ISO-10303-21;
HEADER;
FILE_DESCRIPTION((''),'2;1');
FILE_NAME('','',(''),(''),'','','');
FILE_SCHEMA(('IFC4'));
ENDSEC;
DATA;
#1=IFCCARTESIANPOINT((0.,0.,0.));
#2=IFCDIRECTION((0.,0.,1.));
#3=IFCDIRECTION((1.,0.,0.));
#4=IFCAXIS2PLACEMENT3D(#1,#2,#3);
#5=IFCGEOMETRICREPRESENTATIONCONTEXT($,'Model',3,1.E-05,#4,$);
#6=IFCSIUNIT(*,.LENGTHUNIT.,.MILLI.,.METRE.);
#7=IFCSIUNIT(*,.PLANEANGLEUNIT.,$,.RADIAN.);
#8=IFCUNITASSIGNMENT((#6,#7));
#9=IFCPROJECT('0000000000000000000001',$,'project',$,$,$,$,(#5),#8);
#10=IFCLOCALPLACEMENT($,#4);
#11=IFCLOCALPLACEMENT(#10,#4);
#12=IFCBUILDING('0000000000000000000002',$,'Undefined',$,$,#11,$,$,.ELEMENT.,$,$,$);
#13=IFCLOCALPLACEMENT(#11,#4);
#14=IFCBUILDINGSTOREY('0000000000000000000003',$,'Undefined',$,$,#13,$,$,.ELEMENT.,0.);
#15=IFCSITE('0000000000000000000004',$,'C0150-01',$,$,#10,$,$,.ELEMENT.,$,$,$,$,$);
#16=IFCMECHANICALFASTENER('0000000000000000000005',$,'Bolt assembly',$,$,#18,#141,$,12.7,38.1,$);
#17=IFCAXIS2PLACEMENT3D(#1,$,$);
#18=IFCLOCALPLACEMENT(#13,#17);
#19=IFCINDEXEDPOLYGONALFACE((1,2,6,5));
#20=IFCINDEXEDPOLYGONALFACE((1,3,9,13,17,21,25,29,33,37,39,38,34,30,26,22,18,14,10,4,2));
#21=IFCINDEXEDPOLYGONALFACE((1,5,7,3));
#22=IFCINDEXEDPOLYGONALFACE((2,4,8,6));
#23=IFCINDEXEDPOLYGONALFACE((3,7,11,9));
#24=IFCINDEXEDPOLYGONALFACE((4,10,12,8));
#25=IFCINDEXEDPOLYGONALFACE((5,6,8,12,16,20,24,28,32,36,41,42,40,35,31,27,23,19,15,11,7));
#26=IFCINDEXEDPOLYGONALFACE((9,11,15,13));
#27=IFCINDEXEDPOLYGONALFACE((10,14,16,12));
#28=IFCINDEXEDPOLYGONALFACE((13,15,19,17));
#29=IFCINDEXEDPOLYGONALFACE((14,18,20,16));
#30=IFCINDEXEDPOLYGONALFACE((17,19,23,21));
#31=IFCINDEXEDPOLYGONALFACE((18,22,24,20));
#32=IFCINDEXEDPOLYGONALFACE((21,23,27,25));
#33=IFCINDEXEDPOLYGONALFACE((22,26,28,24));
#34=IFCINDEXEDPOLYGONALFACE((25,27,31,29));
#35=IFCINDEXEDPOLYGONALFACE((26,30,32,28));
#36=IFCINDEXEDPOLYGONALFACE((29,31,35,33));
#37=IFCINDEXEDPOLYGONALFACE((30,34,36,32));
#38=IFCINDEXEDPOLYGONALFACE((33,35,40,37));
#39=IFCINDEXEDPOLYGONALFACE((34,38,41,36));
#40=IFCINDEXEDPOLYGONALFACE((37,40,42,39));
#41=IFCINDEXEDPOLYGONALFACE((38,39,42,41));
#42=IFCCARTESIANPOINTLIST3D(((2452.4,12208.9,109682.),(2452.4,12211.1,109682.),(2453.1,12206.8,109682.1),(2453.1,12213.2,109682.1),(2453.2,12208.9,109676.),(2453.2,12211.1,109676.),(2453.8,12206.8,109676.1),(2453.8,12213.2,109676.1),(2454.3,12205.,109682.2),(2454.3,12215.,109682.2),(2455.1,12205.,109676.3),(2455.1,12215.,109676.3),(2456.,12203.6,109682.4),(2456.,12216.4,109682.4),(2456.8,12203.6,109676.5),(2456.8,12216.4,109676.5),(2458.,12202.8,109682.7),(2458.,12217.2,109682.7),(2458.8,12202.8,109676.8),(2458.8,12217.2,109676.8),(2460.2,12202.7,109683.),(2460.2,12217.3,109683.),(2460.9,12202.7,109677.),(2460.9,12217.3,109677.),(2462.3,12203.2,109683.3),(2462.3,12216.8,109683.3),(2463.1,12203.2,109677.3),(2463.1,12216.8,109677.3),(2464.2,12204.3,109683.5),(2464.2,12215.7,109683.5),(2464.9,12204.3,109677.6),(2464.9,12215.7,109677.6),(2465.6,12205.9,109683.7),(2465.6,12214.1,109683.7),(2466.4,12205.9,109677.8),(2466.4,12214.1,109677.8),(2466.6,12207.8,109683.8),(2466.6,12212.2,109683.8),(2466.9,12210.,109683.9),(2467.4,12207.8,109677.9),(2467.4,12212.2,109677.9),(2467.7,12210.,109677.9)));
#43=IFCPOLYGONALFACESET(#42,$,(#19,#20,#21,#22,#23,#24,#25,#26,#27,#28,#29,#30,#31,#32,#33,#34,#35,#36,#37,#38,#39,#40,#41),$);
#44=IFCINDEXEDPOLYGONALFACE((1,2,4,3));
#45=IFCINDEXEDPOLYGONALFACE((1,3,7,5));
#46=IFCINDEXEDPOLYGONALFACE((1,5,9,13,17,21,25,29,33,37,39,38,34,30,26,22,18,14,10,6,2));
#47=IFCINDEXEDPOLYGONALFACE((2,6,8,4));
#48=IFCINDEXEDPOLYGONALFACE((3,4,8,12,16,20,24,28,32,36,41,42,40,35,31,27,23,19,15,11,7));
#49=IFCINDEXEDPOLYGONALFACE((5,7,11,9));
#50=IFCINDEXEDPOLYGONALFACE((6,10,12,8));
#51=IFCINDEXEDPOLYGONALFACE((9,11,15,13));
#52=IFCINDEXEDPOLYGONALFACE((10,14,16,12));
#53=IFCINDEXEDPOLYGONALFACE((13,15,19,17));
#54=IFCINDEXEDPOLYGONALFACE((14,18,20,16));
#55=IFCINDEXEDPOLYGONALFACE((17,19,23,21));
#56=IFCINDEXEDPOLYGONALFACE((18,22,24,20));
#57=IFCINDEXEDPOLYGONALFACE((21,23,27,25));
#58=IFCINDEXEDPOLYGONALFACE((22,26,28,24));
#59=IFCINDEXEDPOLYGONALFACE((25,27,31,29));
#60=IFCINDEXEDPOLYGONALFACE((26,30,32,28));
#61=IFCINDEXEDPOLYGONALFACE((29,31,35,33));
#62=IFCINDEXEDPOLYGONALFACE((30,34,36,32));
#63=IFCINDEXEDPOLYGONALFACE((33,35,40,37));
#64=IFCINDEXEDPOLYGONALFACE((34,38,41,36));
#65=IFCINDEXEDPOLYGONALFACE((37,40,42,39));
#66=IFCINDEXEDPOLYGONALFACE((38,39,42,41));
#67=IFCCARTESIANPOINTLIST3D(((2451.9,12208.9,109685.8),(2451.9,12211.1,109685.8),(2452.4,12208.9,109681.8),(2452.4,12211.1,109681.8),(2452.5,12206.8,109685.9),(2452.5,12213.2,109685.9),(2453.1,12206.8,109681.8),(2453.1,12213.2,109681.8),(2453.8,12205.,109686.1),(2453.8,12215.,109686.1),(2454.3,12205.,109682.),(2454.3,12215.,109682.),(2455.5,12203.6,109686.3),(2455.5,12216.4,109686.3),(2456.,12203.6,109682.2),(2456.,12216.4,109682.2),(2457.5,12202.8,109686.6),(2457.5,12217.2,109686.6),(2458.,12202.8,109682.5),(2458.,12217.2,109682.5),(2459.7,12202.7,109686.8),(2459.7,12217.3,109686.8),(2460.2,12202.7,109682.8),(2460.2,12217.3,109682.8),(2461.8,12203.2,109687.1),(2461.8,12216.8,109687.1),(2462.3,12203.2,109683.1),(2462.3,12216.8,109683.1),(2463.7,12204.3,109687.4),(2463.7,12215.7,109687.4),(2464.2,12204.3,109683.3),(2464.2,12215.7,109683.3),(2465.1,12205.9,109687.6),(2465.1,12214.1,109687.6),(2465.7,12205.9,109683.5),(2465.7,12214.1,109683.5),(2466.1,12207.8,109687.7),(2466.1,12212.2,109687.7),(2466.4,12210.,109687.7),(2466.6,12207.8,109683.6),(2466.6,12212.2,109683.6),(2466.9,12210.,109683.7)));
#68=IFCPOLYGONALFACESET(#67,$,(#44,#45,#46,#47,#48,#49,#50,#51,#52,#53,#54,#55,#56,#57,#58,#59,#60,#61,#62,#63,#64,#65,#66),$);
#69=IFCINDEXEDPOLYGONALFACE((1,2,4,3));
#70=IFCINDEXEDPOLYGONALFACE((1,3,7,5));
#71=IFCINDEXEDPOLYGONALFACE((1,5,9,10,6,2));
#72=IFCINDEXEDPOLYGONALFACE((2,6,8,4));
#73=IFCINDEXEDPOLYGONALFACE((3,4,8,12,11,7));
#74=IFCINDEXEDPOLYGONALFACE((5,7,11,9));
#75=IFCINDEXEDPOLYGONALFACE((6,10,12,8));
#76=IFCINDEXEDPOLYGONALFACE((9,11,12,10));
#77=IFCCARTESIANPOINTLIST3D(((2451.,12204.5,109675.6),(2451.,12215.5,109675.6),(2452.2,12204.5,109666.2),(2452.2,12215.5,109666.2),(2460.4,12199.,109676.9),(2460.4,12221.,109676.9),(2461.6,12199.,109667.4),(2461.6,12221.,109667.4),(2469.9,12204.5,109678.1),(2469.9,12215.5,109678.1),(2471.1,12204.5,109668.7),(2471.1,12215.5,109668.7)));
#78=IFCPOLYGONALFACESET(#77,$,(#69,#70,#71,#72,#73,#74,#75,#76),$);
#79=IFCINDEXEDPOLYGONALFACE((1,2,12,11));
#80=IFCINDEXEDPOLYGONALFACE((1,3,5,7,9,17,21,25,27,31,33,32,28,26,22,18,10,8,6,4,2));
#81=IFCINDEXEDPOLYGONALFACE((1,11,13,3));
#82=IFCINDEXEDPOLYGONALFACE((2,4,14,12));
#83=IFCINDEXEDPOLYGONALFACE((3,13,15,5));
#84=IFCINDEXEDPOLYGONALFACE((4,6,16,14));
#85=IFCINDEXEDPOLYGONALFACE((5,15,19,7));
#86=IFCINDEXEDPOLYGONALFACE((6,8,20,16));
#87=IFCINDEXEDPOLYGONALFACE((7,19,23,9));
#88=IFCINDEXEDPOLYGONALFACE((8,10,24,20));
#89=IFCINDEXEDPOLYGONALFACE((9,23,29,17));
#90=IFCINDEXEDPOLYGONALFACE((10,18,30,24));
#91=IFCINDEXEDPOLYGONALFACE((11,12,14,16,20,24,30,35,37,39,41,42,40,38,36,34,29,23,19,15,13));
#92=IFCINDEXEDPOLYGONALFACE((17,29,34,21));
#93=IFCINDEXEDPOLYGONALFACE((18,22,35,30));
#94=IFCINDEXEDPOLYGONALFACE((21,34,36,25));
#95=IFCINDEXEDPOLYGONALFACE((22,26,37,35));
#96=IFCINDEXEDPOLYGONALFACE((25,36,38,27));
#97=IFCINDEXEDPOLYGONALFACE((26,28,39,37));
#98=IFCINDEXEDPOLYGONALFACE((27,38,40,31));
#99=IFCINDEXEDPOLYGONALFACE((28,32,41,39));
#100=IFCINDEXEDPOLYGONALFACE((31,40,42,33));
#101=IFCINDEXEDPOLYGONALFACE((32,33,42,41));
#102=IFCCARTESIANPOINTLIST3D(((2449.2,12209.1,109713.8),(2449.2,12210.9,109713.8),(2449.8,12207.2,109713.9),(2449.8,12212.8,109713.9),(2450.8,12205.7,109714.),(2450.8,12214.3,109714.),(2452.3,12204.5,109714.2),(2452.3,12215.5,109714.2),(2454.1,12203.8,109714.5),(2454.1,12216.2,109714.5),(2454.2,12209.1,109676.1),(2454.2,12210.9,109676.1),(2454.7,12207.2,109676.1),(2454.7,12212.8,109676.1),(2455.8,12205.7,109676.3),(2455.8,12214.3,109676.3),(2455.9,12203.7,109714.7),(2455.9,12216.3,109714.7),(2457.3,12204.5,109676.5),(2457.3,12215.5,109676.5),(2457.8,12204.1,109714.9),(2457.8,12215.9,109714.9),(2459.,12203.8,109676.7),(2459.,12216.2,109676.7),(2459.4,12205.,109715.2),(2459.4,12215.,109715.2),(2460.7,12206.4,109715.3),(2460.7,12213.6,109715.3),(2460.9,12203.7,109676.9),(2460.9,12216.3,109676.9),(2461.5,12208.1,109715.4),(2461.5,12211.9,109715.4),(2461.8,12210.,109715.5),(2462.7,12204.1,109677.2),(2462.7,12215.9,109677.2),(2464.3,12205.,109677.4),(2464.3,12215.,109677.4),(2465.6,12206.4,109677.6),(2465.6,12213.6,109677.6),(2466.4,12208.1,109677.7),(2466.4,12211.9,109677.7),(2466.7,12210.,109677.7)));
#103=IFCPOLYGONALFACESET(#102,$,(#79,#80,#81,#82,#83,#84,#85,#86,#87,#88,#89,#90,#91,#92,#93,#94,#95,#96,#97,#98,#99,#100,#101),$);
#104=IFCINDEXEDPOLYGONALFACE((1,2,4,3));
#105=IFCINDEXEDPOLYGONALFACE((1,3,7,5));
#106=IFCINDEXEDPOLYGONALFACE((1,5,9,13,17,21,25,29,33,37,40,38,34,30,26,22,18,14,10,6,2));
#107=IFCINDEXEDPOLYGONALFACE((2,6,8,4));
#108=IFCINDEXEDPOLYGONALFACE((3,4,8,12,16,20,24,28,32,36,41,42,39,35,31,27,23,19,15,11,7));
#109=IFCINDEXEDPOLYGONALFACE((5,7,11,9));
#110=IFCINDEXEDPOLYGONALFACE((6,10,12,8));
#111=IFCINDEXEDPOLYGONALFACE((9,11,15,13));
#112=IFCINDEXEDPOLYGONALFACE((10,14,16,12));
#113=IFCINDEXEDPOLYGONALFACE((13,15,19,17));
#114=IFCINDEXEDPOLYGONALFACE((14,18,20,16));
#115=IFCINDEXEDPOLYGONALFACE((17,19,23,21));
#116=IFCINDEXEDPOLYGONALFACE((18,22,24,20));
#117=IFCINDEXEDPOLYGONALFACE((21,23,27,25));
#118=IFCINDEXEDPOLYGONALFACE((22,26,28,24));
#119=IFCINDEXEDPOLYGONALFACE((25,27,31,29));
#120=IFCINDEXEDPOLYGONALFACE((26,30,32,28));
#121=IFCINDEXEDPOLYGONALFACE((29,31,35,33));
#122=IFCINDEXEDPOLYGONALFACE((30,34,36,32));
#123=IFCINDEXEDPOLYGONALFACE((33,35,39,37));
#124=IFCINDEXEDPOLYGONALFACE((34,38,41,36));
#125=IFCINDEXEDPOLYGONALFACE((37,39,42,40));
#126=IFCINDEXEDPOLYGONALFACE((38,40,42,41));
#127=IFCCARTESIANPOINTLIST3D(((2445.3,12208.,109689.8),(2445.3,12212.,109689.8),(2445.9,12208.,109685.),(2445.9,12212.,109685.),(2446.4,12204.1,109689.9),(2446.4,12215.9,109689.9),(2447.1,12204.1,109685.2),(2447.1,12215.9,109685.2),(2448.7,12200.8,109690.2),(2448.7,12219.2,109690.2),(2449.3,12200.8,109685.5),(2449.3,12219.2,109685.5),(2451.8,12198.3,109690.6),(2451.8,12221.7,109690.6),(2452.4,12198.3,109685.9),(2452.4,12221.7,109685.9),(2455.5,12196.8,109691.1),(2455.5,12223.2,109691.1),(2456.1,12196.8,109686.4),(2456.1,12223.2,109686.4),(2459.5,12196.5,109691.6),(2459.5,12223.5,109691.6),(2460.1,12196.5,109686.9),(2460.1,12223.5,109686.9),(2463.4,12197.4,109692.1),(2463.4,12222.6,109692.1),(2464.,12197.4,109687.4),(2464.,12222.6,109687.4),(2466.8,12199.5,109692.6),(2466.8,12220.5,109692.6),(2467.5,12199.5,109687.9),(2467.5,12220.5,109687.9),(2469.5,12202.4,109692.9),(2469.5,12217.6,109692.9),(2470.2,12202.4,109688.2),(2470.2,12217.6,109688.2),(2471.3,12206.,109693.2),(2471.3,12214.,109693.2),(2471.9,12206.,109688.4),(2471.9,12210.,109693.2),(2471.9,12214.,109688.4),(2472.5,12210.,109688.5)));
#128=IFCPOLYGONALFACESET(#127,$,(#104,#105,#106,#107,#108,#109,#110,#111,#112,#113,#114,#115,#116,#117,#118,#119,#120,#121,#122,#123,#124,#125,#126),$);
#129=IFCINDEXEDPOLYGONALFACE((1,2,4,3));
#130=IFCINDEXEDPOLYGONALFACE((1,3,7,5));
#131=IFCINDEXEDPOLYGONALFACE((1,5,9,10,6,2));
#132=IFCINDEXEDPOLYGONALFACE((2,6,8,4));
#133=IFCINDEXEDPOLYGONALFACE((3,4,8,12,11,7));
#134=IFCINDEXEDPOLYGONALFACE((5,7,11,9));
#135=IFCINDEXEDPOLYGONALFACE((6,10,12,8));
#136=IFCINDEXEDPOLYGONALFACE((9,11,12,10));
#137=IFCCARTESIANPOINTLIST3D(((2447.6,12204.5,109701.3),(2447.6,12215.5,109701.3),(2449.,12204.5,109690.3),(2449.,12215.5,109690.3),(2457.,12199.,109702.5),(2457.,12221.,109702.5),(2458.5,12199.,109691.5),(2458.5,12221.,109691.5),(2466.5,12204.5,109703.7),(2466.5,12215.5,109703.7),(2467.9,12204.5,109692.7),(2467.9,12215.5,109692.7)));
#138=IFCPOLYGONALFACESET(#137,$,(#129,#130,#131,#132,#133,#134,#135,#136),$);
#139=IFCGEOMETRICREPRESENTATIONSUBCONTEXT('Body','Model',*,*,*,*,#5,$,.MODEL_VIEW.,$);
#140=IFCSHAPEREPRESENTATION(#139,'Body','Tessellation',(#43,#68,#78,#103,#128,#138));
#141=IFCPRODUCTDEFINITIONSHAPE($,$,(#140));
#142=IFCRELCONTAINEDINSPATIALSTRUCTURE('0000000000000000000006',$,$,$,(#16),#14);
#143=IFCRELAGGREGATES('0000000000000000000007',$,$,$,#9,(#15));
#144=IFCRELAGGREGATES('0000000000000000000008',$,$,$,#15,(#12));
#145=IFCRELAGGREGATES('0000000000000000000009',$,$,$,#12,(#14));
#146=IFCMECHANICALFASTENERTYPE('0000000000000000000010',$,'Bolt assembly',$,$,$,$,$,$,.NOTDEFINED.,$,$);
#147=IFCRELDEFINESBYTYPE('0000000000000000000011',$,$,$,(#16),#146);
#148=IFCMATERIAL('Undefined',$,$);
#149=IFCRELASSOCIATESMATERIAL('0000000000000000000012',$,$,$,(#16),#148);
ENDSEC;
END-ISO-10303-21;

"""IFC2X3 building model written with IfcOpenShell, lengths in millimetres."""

from ifc_helpers import new_model, si_unit, frame, origin_with_axes, origin_2d_with_axis, place, context, subcontext, project, spatial, polyline, circle, outline, extrude, source, transform, mapped, material, type_object, element, save


model = new_model("IFC2X3")

# Units and contexts
model_context = context("Model", 3, precision=1e-05, world=origin_with_axes())
body_context = subcontext(model_context, "Body", "Model", "MODEL_VIEW")
ifc_project = project(units=[si_unit("LENGTHUNIT", "METRE", prefix="MILLI"), si_unit("PLANEANGLEUNIT", "RADIAN")], contexts=[model_context])

# Site, building, storey
site_placement = place(None, origin_with_axes())
site = spatial("IfcSite", under=ifc_project, at=site_placement, Name="C0150-01", CompositionType="ELEMENT")
building_placement = place(site_placement, origin_with_axes())
building = spatial("IfcBuilding", under=site, at=building_placement, Name="Undefined", CompositionType="ELEMENT")
storey_placement = place(building_placement, origin_with_axes())
storey = spatial("IfcBuildingStorey", under=building, at=storey_placement, Name="Undefined", CompositionType="ELEMENT", Elevation=0.0)

# Mechanical fastener
ifc_material_1 = material(Name="Undefined")
mechanical_fastener_type = type_object("IfcMechanicalFastenerType", Name="Bolt assembly")
shared_shape_1 = source(origin_with_axes(), body_context, "Body", "SweptSolid", [
    extrude(circle(Radius=7.3, at=origin_2d_with_axis()), frame((0.0, -9.9, 0.0), z_axis=(0.0, 1.0, 0.0), x_axis=(1.0, 0.0, 0.0)), (0.0, 0.0, 1.0), 6.0),
    extrude(circle(Radius=7.3, at=origin_2d_with_axis()), frame((0.0, -4.1, 0.0), z_axis=(0.0, 1.0, 0.0), x_axis=(1.0, 0.0, 0.0)), (0.0, 0.0, 1.0), 4.1),
    extrude(outline(polyline([(9.5, -5.5), (9.5, 5.5), (0.0, 11.0), (-9.5, 5.5), (-9.5, -5.5), (0.0, -11.0), (9.5, -5.5)])), frame((0.0, -19.5, 0.0), z_axis=(0.0, 1.0, 0.0), x_axis=(1.0, 0.0, 0.0)), (0.0, 0.0, 1.0), 9.5),
    extrude(circle(Radius=6.3, at=origin_2d_with_axis()), frame((0.0, -10.0, 0.0), z_axis=(0.0, 1.0, 0.0), x_axis=(1.0, 0.0, 0.0)), (0.0, 0.0, 1.0), 38.1),
    extrude(circle(Radius=13.5, at=origin_2d_with_axis()), frame((0.0, 0.0, 0.0), z_axis=(0.0, 1.0, 0.0), x_axis=(1.0, 0.0, 0.0)), (0.0, 0.0, 1.0), 4.8),
    extrude(outline(polyline([(9.5, -5.5), (9.5, 5.5), (0.0, 11.0), (-9.5, 5.5), (-9.5, -5.5), (0.0, -11.0), (9.5, -5.5)])), frame((0.0, 4.8, 0.0), z_axis=(0.0, 1.0, 0.0), x_axis=(1.0, 0.0, 0.0)), (0.0, 0.0, 1.0), 11.1),
])
for number, where, z_axis, x_axis, name in (
    (1, (2459.1, 12210.0, 109686.8), (0.0, -1.0, 0.0), (0.991507, 0.0, 0.130054), "Bolt assembly"),
):
    element("IfcMechanicalFastener", number, at=place(storey_placement, frame(where, z_axis=z_axis, x_axis=x_axis)), inside=storey, type_object=mechanical_fastener_type, material=ifc_material_1, Name=name, NominalDiameter=12.7, NominalLength=38.1, context=body_context, shape_type="MappedRepresentation", body=[
        mapped(shared_shape_1, transform((0.0, 0.0, 0.0))),
    ])

save(model, "model.ifc")
